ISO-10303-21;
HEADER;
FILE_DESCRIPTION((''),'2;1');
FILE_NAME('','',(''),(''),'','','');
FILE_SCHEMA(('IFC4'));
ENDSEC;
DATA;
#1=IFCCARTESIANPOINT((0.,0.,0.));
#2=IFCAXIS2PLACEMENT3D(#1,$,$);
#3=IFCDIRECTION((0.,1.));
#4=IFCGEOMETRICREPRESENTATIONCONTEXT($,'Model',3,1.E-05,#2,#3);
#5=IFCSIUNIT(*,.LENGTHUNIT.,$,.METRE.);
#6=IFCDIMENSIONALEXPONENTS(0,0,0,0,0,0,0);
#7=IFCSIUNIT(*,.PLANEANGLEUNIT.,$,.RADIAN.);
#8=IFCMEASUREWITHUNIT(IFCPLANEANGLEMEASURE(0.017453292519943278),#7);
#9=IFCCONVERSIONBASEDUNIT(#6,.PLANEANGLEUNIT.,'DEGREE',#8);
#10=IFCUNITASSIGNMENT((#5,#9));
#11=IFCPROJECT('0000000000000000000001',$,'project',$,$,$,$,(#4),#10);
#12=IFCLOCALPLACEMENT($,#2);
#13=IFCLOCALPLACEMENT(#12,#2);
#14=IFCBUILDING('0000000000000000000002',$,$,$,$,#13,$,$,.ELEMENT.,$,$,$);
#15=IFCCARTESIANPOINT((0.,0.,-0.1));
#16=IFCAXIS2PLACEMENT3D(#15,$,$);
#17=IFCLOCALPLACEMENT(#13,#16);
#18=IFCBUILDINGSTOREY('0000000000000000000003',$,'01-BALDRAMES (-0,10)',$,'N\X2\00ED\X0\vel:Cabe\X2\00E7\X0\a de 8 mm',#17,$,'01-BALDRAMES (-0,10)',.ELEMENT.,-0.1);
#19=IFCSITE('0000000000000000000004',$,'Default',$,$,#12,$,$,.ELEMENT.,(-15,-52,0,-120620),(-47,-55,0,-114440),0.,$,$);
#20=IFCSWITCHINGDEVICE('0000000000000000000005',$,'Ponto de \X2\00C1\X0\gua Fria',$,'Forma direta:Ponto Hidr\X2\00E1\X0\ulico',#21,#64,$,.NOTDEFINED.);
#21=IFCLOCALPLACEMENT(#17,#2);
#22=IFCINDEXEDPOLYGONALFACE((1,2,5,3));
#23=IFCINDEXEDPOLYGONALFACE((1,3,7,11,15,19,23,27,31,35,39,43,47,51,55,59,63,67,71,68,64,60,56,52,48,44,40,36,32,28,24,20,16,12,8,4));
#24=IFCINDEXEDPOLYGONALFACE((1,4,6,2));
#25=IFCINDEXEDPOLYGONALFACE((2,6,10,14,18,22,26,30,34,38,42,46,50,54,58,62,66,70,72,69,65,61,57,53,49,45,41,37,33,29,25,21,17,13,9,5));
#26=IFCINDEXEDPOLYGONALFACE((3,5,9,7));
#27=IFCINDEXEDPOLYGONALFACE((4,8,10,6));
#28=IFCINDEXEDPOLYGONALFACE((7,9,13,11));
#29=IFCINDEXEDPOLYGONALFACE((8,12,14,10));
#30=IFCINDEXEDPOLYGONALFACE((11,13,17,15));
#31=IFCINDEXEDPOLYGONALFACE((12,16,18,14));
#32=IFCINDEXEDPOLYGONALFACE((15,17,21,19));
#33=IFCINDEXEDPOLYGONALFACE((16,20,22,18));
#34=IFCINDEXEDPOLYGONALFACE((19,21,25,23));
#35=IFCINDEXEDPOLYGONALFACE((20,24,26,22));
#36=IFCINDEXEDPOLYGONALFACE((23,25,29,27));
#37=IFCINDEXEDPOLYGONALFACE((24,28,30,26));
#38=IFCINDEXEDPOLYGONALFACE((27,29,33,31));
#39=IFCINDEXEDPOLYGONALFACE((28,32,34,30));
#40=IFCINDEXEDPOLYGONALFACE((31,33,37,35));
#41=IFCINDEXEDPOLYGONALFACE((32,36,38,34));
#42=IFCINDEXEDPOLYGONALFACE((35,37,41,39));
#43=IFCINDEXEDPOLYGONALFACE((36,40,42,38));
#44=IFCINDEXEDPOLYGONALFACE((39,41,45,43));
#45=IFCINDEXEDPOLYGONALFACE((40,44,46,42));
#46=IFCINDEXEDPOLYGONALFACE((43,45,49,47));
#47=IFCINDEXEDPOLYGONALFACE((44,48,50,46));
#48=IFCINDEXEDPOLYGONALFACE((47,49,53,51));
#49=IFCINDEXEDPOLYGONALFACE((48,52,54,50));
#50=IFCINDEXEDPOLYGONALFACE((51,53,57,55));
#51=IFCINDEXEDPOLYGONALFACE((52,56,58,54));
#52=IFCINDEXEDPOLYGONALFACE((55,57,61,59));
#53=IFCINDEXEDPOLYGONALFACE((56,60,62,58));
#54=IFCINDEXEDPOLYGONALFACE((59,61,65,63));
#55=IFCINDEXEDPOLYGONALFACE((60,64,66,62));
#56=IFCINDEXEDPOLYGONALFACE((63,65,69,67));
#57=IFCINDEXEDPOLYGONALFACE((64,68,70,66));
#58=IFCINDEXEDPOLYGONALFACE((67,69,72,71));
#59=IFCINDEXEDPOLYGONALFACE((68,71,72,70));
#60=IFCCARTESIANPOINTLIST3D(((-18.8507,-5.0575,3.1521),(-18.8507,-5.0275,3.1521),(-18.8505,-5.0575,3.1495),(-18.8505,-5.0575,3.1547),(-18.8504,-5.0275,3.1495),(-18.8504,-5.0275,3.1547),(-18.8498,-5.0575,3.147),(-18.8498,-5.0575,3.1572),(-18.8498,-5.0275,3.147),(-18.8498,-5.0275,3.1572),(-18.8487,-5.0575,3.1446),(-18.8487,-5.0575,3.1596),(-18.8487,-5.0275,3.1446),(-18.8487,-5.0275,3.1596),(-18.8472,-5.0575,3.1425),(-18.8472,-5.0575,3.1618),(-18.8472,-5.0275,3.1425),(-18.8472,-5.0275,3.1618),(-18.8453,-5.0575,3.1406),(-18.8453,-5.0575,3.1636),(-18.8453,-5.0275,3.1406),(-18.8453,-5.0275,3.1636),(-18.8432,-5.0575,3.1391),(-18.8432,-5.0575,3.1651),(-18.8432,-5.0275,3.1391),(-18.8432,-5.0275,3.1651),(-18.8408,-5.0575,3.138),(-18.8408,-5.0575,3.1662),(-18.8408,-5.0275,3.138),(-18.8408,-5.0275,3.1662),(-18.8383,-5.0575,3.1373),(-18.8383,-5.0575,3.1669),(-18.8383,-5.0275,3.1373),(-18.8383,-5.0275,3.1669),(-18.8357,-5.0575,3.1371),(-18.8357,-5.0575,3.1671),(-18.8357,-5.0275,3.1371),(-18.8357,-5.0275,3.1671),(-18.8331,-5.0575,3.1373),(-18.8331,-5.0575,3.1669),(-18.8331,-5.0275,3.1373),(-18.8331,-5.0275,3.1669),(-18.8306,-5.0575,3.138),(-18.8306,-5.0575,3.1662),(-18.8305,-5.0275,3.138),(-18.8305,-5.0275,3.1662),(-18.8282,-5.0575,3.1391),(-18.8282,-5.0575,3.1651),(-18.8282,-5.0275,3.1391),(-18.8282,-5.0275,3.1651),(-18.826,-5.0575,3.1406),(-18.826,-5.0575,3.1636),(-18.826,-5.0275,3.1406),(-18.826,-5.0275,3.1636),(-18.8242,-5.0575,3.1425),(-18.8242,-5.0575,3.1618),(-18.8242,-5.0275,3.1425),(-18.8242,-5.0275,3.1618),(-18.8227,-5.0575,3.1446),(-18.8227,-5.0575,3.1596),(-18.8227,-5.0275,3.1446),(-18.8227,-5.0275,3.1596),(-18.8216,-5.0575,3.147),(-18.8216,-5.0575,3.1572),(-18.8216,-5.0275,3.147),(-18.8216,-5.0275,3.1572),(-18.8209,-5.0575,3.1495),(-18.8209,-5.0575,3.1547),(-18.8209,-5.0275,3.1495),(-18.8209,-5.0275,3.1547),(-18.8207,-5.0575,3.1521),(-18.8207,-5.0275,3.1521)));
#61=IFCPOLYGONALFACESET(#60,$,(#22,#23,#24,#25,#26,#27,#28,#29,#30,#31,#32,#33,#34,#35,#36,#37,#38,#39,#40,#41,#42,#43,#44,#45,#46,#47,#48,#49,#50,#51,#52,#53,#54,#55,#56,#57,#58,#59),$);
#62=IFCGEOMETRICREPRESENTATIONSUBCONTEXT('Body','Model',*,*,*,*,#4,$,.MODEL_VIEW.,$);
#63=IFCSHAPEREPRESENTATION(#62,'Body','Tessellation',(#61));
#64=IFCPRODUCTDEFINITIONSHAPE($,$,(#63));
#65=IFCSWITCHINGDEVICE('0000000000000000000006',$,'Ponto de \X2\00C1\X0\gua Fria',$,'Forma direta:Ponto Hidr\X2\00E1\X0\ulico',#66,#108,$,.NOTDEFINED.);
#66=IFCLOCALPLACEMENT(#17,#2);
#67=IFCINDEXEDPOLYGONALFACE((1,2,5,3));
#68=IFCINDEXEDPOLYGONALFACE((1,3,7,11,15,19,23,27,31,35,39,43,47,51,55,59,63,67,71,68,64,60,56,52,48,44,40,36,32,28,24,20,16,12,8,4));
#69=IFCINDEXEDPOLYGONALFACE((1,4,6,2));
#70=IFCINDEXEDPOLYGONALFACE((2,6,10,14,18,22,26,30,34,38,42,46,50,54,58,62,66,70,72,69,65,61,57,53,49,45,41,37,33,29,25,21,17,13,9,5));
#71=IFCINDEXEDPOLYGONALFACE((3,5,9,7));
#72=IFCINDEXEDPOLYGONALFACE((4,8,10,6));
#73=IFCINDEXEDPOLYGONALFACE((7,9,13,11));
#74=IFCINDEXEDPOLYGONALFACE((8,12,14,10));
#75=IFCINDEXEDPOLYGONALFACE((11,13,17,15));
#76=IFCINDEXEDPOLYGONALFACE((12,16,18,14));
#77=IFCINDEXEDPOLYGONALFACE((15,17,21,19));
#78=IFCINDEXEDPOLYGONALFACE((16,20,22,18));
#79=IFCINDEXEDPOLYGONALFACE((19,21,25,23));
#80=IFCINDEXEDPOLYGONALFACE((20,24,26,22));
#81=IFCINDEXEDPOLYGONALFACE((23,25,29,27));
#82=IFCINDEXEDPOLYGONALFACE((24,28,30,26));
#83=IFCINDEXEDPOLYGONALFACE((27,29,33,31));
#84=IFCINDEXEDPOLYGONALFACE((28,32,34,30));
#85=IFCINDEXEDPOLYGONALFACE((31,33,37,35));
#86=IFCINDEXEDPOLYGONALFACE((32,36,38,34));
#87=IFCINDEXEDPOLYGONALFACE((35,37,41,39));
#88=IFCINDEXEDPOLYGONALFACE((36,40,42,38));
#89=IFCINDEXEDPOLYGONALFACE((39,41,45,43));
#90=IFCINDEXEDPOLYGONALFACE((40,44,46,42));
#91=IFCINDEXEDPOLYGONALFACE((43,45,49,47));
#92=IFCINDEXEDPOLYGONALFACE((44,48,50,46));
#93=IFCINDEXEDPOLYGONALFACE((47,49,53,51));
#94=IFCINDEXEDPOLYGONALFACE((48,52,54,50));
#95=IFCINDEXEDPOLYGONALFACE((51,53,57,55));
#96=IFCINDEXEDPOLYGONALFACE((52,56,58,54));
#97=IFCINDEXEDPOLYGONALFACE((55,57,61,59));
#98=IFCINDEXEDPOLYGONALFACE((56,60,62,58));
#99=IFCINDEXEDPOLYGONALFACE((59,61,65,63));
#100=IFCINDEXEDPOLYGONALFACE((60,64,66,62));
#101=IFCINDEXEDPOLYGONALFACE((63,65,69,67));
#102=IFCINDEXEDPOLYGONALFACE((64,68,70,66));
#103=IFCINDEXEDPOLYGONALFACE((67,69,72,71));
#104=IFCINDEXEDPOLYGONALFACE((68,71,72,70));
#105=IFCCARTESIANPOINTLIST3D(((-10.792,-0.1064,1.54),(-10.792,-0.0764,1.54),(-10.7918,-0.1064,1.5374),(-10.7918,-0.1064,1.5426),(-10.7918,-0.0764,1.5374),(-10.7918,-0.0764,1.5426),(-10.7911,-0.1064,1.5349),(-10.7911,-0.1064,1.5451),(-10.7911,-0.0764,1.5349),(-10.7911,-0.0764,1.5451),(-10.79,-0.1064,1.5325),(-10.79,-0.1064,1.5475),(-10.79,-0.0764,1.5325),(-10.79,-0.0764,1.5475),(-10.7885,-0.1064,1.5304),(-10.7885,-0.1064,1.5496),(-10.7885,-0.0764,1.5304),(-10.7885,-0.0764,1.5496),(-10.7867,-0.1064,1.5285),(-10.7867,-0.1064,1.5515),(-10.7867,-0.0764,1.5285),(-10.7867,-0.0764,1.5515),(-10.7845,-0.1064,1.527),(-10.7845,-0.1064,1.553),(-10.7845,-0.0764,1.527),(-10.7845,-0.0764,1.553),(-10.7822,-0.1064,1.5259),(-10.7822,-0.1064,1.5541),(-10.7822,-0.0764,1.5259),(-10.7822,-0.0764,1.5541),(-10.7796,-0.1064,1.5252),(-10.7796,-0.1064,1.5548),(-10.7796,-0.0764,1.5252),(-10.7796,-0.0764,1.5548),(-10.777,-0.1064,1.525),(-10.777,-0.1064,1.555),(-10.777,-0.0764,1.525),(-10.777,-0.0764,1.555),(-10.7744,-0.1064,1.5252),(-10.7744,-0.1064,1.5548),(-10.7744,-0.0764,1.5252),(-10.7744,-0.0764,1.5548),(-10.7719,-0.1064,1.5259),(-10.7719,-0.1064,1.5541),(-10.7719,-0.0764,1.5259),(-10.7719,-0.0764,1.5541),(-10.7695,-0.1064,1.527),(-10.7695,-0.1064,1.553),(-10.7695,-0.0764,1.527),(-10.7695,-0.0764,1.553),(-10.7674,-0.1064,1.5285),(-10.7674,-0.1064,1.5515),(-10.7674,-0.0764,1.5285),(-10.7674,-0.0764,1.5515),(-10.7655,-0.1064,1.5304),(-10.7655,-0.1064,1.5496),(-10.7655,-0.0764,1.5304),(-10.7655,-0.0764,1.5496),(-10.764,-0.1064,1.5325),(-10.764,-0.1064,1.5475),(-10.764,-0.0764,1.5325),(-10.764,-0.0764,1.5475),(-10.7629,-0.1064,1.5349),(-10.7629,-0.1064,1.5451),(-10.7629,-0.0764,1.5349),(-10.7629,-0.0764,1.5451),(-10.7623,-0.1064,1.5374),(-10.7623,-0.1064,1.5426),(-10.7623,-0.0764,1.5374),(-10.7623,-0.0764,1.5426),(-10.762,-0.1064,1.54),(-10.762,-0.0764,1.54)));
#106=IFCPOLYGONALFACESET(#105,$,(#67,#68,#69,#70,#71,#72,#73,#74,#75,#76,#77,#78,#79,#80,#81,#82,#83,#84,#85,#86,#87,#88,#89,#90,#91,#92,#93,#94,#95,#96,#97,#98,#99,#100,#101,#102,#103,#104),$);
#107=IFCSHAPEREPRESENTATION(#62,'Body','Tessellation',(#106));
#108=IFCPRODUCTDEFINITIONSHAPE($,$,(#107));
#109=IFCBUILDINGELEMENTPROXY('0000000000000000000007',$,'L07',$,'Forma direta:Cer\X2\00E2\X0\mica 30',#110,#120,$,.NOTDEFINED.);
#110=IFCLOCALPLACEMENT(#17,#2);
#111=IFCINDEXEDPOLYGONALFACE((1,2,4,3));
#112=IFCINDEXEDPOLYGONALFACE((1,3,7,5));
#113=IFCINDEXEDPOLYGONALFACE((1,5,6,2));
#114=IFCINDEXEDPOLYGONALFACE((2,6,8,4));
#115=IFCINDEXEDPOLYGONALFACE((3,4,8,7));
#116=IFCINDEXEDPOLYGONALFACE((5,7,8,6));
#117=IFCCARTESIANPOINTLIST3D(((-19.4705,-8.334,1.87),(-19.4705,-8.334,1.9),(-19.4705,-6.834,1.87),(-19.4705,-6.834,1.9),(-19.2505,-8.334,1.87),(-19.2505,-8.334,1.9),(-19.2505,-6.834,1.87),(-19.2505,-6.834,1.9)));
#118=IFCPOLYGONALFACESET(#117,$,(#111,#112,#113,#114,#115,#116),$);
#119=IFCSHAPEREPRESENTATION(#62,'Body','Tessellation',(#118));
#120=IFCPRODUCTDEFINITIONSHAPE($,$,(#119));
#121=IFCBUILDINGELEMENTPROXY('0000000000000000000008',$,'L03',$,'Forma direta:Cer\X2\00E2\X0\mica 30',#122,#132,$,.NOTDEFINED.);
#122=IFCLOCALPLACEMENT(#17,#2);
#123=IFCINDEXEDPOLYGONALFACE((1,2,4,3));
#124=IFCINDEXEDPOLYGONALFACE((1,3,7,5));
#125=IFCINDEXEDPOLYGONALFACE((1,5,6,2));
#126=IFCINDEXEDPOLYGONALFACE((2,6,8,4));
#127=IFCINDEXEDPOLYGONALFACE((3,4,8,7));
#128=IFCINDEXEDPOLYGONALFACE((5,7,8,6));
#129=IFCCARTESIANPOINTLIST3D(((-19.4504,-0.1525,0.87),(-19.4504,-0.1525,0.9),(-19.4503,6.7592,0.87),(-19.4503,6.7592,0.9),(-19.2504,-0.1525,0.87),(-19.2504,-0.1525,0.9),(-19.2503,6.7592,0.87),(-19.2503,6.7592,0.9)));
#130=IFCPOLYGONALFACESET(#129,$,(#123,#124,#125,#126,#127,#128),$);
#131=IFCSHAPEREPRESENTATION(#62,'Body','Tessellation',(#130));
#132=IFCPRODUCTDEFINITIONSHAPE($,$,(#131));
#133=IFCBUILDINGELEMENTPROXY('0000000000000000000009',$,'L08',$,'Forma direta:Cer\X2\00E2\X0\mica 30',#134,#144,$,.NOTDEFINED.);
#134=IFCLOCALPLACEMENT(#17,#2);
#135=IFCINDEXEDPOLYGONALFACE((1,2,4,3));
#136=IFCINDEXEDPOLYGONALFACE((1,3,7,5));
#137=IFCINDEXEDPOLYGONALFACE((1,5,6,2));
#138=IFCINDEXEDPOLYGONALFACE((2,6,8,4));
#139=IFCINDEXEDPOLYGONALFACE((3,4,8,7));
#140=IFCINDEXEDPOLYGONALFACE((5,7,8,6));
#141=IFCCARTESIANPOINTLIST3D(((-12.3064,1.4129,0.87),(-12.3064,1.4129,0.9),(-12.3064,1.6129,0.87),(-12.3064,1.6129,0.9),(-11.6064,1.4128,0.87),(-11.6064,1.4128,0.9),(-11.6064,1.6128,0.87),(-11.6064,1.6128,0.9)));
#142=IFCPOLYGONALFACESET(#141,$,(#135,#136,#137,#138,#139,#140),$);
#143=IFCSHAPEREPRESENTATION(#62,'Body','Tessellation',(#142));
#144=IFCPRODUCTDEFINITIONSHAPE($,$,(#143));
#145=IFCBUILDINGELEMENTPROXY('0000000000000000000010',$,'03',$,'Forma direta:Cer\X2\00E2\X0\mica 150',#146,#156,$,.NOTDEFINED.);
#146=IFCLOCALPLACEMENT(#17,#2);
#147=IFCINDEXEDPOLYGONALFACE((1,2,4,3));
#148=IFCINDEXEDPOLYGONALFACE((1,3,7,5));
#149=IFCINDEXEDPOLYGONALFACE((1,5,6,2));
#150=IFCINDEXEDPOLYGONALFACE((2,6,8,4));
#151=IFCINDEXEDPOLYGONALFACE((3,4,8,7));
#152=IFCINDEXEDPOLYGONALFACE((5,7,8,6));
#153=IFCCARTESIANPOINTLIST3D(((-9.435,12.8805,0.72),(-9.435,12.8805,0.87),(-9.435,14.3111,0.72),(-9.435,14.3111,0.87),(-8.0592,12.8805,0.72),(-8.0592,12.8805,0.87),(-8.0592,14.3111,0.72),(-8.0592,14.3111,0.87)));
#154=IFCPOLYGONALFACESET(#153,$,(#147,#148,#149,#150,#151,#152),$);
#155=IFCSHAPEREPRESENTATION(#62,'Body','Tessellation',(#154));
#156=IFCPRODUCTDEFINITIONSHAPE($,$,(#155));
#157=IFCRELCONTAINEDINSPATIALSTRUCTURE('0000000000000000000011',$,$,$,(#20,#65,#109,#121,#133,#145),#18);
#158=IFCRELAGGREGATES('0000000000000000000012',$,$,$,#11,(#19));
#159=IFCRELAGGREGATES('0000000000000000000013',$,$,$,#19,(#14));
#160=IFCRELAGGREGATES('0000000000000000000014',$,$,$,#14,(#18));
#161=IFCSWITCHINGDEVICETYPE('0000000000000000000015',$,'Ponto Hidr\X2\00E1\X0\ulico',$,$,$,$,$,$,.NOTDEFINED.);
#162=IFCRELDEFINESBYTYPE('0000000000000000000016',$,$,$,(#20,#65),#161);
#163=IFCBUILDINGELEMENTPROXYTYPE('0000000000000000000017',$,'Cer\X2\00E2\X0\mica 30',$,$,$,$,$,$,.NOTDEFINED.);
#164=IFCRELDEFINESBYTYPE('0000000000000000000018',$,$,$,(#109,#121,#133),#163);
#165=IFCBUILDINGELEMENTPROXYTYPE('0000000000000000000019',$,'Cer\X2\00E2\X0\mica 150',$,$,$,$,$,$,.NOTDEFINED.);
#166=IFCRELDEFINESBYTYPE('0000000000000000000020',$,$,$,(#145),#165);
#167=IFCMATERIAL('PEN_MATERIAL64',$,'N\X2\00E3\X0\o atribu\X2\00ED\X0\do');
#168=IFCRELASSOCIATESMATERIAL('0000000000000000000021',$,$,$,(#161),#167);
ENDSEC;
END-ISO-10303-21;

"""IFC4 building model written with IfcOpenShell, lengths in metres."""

from ifc_helpers import new_model, entity, si_unit, converted_unit, direction, frame, origin, place, context, subcontext, project, spatial, indexed_curve, outline, extrude, material, type_object, element, save


model = new_model("IFC4")

# Units and contexts
model_context = context("Model", 3, precision=1e-05, world=origin(), true_north=direction((0.0, 1.0)))
body_context = subcontext(model_context, "Body", "Model", "MODEL_VIEW")
ifc_project = project(units=[si_unit("LENGTHUNIT", "METRE"), converted_unit("PLANEANGLEUNIT", "DEGREE", entity("IfcPlaneAngleMeasure", 0.017453292519943278), si_unit("PLANEANGLEUNIT", "RADIAN"), dimensions=[0, 0, 0, 0, 0, 0, 0])], contexts=[model_context])

# Site, building, storey
site_placement = place(None, origin())
site = spatial("IfcSite", under=ifc_project, at=site_placement, Name="Default", CompositionType="ELEMENT", RefLatitude=(-15, -52, 0, -120620), RefLongitude=(-47, -55, 0, -114440), RefElevation=0.0)
building_placement = place(site_placement, origin())
building = spatial("IfcBuilding", under=site, at=building_placement, CompositionType="ELEMENT")
storey_placement = place(building_placement, frame((0.0, 0.0, -0.1)))
storey = spatial("IfcBuildingStorey", under=building, at=storey_placement, Name="01-BALDRAMES (-0,10)", ObjectType="Nível:Cabeça de 8 mm", LongName="01-BALDRAMES (-0,10)", CompositionType="ELEMENT", Elevation=-0.1)

# Switching devices
ifc_material_1 = material(Name="PEN_MATERIAL64", Category="Não atribuído")
switching_device_type = type_object("IfcSwitchingDeviceType", Name="Ponto Hidráulico", PredefinedType="NOTDEFINED", material=ifc_material_1)
switching_device_1_placement = place(storey_placement, origin())
element("IfcSwitchingDevice", 1, at=switching_device_1_placement, inside=storey, type_object=switching_device_type, Name="Ponto de Água Fria", ObjectType="Forma direta:Ponto Hidráulico", PredefinedType="NOTDEFINED", context=body_context, shape_type="SweptSolid", body=[
    extrude(outline(indexed_curve([(-0.0013, -0.0149), (0.0013, -0.0149), (0.0039, -0.0145), (0.0063, -0.0136), (0.0086, -0.0123), (0.0106, -0.0106), (0.0123, -0.0086), (0.0136, -0.0063), (0.0145, -0.0039), (0.0149, -0.0013), (0.0149, 0.0013), (0.0145, 0.0039), (0.0136, 0.0063), (0.0123, 0.0086), (0.0106, 0.0106), (0.0086, 0.0123), (0.0063, 0.0136), (0.0039, 0.0145), (0.0013, 0.0149), (-0.0013, 0.0149), (-0.0039, 0.0145), (-0.0063, 0.0136), (-0.0086, 0.0123), (-0.0106, 0.0106), (-0.0123, 0.0086), (-0.0136, 0.0063), (-0.0145, 0.0039), (-0.0149, 0.0013), (-0.0149, -0.0013), (-0.0145, -0.0039), (-0.0136, -0.0063), (-0.0123, -0.0086), (-0.0106, -0.0106), (-0.0086, -0.0123), (-0.0063, -0.0136), (-0.0039, -0.0145), (-0.0013, -0.0149)], self_intersect=False)), frame((-18.8357, -5.0575, 3.1521), z_axis=(0.000435, 1.0, 0.0), x_axis=(-0.965926, 0.00042, 0.258819)), (0.0, 0.0, 1.0), 0.03),
])
switching_device_2_placement = place(storey_placement, origin())
element("IfcSwitchingDevice", 2, at=switching_device_2_placement, inside=storey, type_object=switching_device_type, Name="Ponto de Água Fria", ObjectType="Forma direta:Ponto Hidráulico", PredefinedType="NOTDEFINED", context=body_context, shape_type="SweptSolid", body=[
    extrude(outline(indexed_curve([(-0.0013, -0.0149), (0.0013, -0.0149), (0.0039, -0.0145), (0.0063, -0.0136), (0.0086, -0.0123), (0.0106, -0.0106), (0.0123, -0.0086), (0.0136, -0.0063), (0.0145, -0.0039), (0.0149, -0.0013), (0.0149, 0.0013), (0.0145, 0.0039), (0.0136, 0.0063), (0.0123, 0.0086), (0.0106, 0.0106), (0.0086, 0.0123), (0.0063, 0.0136), (0.0039, 0.0145), (0.0013, 0.0149), (-0.0013, 0.0149), (-0.0039, 0.0145), (-0.0063, 0.0136), (-0.0086, 0.0123), (-0.0106, 0.0106), (-0.0123, 0.0086), (-0.0136, 0.0063), (-0.0145, 0.0039), (-0.0149, 0.0013), (-0.0149, -0.0013), (-0.0145, -0.0039), (-0.0136, -0.0063), (-0.0123, -0.0086), (-0.0106, -0.0106), (-0.0086, -0.0123), (-0.0063, -0.0136), (-0.0039, -0.0145), (-0.0013, -0.0149)], self_intersect=False)), frame((-10.777, -0.1064, 1.54), z_axis=(0.000435, 1.0, 0.0), x_axis=(-0.965926, 0.00042, 0.258819)), (0.0, 0.0, 1.0), 0.03),
])

# Building element proxies
building_element_proxy_type_1 = type_object("IfcBuildingElementProxyType", Name="Cerâmica 30", PredefinedType="NOTDEFINED")
proxy_1_placement = place(storey_placement, origin())
element("IfcBuildingElementProxy", 3, at=proxy_1_placement, inside=storey, type_object=building_element_proxy_type_1, Name="L07", ObjectType="Forma direta:Cerâmica 30", PredefinedType="NOTDEFINED", context=body_context, shape_type="SweptSolid", body=[
    extrude(outline(indexed_curve([(-0.75, -0.11), (0.75, -0.11), (0.75, 0.11), (-0.75, 0.11), (-0.75, -0.11)], self_intersect=False)), frame((-19.3605, -7.584, 1.87), z_axis=(0.0, 0.0, 1.0), x_axis=(-0.000006, 1.0, 0.0)), (0.0, 0.0, 1.0), 0.03),
])
proxy_2_placement = place(storey_placement, origin())
element("IfcBuildingElementProxy", 4, at=proxy_2_placement, inside=storey, type_object=building_element_proxy_type_1, Name="L03", ObjectType="Forma direta:Cerâmica 30", PredefinedType="NOTDEFINED", context=body_context, shape_type="SweptSolid", body=[
    extrude(outline(indexed_curve([(-3.4559, -0.1), (3.4559, -0.1), (3.4559, 0.1), (-3.4559, 0.1), (-3.4559, -0.1)], self_intersect=False)), frame((-19.3504, 3.3033, 0.87), z_axis=(0.0, 0.0, 1.0), x_axis=(0.000013, 1.0, 0.0)), (0.0, 0.0, 1.0), 0.03),
])
proxy_3_placement = place(storey_placement, origin())
element("IfcBuildingElementProxy", 5, at=proxy_3_placement, inside=storey, type_object=building_element_proxy_type_1, Name="L08", ObjectType="Forma direta:Cerâmica 30", PredefinedType="NOTDEFINED", context=body_context, shape_type="SweptSolid", body=[
    extrude(outline(indexed_curve([(-0.1, -0.35), (0.1, -0.35), (0.1, 0.35), (-0.1, 0.35), (-0.1, -0.35)], self_intersect=False)), frame((-11.9564, 1.5129, 0.87), z_axis=(0.0, 0.0, 1.0), x_axis=(0.000013, 1.0, 0.0)), (0.0, 0.0, 1.0), 0.03),
])
building_element_proxy_type_2 = type_object("IfcBuildingElementProxyType", Name="Cerâmica 150", PredefinedType="NOTDEFINED")
proxy_4_placement = place(storey_placement, origin())
element("IfcBuildingElementProxy", 6, at=proxy_4_placement, inside=storey, type_object=building_element_proxy_type_2, Name="03", ObjectType="Forma direta:Cerâmica 150", PredefinedType="NOTDEFINED", context=body_context, shape_type="SweptSolid", body=[
    extrude(outline(indexed_curve([(-0.7153, -0.6879), (0.7153, -0.6879), (0.7153, 0.6879), (-0.7153, 0.6879), (-0.7153, -0.6879)], self_intersect=False)), frame((-8.7471, 13.5958, 0.72), z_axis=(0.0, 0.0, 1.0), x_axis=(0.000013, 1.0, 0.0)), (0.0, 0.0, 1.0), 0.15),
])

save(model, "model.ifc")
